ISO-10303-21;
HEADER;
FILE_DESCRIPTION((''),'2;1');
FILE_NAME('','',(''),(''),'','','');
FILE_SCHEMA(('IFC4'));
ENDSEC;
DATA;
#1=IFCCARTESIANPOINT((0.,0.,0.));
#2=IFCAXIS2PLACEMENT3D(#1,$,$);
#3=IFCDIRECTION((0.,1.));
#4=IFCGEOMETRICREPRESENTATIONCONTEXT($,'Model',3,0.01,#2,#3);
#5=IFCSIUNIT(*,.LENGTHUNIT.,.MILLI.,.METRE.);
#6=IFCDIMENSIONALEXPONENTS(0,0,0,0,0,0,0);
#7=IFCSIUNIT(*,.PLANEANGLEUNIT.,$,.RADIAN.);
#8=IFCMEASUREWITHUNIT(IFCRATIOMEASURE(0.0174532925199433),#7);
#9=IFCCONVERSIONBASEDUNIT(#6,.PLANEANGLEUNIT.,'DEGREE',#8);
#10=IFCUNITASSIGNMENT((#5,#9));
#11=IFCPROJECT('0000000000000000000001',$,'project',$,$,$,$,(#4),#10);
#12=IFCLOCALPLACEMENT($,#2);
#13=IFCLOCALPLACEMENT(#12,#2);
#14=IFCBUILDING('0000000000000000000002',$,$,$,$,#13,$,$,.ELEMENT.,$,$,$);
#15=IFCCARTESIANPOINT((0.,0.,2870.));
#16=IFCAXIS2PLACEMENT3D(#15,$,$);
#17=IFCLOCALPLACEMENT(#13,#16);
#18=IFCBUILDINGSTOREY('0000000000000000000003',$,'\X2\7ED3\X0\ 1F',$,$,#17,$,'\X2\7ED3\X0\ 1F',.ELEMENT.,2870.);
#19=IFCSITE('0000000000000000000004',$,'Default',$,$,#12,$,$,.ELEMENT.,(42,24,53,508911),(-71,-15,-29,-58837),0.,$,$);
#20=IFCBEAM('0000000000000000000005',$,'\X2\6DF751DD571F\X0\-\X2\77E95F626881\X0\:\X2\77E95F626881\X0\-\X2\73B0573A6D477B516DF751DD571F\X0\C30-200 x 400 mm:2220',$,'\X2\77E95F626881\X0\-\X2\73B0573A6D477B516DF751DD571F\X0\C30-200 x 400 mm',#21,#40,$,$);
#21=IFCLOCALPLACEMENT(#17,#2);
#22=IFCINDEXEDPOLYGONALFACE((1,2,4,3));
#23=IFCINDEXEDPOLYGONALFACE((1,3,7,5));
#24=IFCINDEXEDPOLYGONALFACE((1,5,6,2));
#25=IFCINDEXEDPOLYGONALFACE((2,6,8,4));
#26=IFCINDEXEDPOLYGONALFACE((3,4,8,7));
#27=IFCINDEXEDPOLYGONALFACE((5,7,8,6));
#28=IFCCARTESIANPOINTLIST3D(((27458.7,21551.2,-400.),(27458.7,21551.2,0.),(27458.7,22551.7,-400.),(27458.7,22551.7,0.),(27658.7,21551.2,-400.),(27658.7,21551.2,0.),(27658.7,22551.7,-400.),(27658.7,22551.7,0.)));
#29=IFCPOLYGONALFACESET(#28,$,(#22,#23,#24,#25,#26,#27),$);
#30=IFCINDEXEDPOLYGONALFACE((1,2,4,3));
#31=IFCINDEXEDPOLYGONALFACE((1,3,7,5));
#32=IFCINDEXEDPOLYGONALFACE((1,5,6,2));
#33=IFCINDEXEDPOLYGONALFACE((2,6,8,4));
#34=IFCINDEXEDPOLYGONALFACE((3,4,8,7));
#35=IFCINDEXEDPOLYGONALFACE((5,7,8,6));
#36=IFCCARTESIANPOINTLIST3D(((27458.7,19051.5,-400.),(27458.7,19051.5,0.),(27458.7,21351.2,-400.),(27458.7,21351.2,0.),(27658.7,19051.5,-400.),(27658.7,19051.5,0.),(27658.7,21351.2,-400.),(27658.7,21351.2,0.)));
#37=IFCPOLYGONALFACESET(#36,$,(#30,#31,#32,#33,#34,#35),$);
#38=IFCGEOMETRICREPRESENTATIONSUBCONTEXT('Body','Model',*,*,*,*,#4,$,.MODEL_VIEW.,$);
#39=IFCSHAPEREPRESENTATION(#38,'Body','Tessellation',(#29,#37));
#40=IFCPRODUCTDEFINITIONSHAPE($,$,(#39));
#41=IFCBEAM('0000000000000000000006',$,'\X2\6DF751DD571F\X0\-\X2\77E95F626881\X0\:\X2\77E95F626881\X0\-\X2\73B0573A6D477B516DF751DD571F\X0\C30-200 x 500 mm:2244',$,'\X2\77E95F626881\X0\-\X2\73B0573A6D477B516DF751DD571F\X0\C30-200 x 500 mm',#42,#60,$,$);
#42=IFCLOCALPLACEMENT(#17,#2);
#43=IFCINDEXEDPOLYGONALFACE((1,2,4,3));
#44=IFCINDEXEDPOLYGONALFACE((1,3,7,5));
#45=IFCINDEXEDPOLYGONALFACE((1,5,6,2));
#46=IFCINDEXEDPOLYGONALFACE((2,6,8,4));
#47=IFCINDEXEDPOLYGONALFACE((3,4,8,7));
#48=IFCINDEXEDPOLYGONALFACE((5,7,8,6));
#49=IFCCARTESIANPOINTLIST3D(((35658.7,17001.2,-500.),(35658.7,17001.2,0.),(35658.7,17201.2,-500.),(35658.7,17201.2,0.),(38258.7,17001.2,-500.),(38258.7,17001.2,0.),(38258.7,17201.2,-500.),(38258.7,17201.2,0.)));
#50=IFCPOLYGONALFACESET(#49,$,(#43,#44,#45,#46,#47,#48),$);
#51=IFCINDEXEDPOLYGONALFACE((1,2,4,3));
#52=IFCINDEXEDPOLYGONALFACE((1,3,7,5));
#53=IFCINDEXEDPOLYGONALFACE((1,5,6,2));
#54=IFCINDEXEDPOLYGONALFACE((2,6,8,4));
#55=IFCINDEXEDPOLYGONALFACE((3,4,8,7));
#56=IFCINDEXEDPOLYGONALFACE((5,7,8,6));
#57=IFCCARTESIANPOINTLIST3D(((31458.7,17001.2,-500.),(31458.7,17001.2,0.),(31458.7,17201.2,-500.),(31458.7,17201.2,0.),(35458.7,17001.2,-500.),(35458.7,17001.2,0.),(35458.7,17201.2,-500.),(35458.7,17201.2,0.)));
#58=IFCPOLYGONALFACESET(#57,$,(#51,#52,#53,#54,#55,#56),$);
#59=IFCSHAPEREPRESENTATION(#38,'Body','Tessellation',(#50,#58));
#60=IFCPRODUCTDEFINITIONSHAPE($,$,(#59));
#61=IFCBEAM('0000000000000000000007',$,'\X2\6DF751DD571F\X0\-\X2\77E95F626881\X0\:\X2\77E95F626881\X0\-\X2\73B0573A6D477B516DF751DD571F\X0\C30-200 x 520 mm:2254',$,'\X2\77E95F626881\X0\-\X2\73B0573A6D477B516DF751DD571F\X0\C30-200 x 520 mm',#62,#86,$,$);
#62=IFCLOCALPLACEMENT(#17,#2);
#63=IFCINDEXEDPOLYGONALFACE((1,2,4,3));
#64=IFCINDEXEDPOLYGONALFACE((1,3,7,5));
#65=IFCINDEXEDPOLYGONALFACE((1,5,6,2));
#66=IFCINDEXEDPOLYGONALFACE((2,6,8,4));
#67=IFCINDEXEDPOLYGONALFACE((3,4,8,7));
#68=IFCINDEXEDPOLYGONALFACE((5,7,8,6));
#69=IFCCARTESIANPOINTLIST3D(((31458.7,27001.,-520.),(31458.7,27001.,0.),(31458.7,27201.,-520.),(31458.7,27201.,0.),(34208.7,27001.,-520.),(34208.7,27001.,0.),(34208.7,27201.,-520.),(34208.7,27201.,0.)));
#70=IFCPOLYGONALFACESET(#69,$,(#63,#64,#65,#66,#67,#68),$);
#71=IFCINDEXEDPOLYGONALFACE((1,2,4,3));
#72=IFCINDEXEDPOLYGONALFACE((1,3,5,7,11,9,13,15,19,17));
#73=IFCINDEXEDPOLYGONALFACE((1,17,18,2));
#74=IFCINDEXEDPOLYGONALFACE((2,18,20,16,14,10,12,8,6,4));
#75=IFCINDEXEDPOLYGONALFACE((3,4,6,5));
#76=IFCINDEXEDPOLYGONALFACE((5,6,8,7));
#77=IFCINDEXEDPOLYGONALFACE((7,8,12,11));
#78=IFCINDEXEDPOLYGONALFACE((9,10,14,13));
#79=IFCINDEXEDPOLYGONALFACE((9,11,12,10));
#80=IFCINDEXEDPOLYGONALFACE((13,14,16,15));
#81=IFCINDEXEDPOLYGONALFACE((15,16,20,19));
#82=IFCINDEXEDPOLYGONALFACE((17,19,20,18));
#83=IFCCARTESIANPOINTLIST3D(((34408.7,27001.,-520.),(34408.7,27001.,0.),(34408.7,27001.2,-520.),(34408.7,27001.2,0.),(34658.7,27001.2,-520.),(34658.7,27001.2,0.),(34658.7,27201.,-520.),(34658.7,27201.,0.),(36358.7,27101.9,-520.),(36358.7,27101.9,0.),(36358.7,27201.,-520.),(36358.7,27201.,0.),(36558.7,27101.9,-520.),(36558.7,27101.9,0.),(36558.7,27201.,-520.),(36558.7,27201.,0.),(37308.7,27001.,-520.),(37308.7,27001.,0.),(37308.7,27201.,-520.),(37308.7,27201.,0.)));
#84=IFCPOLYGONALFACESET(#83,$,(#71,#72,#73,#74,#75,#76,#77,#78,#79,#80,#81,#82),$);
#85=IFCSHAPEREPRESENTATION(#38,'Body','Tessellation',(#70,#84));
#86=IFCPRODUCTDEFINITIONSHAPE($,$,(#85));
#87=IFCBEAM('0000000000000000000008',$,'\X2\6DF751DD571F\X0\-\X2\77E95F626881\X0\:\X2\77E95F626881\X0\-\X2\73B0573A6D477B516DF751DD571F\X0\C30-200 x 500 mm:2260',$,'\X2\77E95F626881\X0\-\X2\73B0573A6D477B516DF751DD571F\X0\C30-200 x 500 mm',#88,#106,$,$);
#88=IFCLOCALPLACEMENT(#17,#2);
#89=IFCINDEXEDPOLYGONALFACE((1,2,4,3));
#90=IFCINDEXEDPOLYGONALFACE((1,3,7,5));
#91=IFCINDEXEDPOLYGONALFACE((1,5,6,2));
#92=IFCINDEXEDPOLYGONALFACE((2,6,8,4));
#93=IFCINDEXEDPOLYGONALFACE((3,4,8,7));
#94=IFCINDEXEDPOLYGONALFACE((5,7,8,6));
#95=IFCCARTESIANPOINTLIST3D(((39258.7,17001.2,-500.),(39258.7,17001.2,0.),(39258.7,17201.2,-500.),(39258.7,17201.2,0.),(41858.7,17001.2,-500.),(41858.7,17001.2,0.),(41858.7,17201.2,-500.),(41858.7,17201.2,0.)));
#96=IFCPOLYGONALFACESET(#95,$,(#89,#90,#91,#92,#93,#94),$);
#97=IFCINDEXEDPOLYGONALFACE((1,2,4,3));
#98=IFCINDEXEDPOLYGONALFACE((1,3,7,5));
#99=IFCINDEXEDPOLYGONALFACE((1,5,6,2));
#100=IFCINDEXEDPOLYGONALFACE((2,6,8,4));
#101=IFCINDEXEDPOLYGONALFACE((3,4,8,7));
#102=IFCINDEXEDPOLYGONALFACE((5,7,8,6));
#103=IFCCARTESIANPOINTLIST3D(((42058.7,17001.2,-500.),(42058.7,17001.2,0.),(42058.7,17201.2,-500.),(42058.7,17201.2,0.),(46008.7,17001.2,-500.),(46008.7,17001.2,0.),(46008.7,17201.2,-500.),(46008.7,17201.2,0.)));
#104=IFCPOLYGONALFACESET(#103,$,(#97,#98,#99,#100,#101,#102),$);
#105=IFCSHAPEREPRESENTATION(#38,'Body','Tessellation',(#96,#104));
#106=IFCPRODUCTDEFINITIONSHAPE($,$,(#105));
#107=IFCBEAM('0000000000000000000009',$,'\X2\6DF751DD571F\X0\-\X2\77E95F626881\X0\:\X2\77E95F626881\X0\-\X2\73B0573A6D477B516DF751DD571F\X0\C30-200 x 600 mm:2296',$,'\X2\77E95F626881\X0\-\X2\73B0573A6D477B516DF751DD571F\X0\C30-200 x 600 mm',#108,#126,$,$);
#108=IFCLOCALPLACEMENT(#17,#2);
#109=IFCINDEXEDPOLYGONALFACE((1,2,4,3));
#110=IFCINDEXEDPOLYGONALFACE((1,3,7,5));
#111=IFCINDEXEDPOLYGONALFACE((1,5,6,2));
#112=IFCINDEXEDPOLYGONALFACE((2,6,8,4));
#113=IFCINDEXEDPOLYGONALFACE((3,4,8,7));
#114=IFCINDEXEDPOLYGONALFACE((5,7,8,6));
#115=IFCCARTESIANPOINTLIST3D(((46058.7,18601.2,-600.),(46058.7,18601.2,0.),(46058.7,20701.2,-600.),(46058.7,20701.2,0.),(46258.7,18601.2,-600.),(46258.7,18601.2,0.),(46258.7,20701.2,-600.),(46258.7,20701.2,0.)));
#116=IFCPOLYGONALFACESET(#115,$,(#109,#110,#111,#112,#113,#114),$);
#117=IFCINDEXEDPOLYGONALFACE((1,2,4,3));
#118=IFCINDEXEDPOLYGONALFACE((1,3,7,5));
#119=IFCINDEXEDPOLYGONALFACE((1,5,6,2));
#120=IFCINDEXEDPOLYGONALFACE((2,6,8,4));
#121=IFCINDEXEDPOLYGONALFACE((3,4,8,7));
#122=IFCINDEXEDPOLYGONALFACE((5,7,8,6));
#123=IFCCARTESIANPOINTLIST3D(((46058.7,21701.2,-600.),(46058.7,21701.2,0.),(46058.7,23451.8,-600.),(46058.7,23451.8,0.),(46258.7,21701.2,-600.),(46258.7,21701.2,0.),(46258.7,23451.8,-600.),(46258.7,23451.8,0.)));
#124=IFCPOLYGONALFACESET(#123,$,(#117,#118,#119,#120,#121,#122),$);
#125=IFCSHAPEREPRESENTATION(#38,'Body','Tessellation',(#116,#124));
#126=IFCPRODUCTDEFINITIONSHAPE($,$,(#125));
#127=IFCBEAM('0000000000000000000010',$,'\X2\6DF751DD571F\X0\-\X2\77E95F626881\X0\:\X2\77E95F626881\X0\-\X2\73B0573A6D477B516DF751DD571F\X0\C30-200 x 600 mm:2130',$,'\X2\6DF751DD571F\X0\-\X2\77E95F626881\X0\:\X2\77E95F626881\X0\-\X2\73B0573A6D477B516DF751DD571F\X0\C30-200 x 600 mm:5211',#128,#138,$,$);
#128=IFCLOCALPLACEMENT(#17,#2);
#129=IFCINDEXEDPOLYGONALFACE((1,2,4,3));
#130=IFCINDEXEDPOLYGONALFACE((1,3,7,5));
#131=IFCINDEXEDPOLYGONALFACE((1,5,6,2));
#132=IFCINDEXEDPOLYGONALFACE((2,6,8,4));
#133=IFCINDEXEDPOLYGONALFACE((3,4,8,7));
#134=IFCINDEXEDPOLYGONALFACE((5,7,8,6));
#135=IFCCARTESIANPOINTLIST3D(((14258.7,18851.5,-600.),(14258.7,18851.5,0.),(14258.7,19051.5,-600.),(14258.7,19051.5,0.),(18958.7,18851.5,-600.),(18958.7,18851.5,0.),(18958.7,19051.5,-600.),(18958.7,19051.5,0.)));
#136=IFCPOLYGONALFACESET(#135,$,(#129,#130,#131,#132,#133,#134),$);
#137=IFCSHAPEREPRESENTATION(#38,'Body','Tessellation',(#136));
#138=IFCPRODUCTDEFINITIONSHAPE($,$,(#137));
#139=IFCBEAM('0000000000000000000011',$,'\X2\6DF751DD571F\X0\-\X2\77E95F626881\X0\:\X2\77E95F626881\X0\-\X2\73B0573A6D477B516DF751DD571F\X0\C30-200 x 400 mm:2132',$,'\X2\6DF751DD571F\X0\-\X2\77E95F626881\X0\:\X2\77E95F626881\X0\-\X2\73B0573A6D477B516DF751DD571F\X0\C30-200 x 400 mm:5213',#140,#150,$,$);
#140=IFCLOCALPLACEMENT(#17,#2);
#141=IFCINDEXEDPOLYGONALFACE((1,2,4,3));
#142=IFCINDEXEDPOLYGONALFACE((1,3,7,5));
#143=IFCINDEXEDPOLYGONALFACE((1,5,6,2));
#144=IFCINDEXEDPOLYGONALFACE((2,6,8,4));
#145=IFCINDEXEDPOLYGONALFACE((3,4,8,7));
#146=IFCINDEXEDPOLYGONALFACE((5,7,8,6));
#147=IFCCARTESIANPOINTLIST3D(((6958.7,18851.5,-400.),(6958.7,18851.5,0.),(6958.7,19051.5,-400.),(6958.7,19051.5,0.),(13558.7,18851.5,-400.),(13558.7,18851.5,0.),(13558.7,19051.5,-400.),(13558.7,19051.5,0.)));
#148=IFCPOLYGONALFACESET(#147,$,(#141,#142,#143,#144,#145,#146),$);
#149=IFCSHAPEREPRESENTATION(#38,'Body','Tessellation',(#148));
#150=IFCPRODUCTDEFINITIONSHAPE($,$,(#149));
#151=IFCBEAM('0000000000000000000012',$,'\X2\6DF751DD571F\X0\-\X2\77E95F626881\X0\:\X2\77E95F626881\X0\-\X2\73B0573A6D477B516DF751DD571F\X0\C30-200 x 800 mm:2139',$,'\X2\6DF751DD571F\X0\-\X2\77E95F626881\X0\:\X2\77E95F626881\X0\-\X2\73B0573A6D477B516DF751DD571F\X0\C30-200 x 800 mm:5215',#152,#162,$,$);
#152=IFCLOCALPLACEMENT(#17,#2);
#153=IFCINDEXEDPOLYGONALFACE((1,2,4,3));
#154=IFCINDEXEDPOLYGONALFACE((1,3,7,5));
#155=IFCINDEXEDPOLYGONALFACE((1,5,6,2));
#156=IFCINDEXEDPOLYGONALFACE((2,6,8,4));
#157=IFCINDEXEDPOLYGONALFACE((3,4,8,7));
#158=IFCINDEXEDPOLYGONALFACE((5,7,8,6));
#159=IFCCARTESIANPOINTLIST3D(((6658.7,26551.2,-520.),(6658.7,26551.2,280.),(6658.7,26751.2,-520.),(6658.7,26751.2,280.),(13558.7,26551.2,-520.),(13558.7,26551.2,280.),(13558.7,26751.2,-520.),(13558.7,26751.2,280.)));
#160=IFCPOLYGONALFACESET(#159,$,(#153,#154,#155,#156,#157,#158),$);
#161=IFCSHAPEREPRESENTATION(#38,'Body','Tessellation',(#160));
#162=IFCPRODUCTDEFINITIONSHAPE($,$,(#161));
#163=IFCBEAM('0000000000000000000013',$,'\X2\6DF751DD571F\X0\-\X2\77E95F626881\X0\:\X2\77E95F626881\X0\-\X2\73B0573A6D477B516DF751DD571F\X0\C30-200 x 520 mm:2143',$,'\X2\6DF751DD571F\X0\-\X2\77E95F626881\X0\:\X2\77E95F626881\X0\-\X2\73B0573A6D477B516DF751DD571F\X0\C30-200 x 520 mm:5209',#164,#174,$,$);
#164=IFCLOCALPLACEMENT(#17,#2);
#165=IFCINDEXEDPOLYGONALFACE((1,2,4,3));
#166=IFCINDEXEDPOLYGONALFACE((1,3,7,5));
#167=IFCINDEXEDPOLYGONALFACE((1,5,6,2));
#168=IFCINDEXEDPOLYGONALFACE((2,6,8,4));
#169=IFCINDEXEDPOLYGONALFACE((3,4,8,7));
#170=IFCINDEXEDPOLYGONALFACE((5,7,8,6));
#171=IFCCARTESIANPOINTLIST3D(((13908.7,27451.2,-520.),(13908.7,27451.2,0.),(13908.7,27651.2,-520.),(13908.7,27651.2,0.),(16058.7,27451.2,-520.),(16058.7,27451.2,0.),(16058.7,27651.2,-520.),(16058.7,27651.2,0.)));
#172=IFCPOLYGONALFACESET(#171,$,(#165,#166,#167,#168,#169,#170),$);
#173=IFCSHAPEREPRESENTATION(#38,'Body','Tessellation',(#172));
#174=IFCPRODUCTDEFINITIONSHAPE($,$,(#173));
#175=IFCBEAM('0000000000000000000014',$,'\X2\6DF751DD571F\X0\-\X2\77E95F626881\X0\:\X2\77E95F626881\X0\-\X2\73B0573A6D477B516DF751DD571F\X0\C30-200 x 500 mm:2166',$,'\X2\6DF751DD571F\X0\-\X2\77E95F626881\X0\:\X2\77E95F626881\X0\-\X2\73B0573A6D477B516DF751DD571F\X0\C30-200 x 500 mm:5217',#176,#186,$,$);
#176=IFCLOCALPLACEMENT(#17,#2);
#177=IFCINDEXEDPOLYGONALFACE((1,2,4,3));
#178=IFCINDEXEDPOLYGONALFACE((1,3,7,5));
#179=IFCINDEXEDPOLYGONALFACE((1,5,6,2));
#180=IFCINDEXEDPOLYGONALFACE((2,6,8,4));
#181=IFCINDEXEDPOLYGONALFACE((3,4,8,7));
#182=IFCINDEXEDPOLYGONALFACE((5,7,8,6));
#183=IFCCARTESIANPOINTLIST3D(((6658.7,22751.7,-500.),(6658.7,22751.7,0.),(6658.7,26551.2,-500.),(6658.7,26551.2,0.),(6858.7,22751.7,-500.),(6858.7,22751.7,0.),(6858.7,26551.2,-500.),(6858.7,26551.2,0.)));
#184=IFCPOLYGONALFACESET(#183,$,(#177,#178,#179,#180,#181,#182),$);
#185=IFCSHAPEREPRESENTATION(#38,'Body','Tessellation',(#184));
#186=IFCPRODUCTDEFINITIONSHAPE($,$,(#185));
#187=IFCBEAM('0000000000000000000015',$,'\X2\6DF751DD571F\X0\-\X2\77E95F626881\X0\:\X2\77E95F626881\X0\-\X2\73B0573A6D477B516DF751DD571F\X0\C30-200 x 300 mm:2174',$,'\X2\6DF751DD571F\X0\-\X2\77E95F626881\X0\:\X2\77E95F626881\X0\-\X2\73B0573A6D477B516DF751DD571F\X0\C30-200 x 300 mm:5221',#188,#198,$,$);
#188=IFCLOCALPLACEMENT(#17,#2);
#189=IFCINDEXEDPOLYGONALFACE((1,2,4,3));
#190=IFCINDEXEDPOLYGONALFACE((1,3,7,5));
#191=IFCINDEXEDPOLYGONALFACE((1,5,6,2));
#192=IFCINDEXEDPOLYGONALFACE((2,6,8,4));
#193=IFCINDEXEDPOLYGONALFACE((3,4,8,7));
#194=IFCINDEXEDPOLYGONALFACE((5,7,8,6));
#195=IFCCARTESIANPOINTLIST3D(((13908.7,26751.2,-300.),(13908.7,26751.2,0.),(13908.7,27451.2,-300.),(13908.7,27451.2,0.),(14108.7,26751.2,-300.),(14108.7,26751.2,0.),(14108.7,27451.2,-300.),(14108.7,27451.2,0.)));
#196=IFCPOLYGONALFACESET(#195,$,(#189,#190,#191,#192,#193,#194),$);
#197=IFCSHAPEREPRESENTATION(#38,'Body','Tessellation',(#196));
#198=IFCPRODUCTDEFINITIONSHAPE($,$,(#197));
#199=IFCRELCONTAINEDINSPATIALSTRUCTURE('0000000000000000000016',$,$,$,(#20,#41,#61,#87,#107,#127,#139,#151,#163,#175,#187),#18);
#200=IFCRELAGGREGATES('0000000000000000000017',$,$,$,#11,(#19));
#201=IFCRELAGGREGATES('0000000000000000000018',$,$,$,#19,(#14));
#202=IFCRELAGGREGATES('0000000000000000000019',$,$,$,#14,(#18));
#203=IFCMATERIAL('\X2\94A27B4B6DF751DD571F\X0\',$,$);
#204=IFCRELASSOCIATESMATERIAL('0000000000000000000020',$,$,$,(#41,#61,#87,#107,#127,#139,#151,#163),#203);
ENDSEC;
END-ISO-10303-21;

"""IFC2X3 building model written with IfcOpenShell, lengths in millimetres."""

from ifc_helpers import new_model, entity, si_unit, converted_unit, direction, frame, frame_2d, origin, place, context, subcontext, project, spatial, polyline, rectangle, outline, extrude, source, transform, mapped, material, element, save


model = new_model("IFC2X3")

# Units and contexts
model_context = context("Model", 3, precision=0.01, world=origin(), true_north=direction((0.0, 1.0)))
body_context = subcontext(model_context, "Body", "Model", "MODEL_VIEW")
ifc_project = project(units=[si_unit("LENGTHUNIT", "METRE", prefix="MILLI"), converted_unit("PLANEANGLEUNIT", "DEGREE", entity("IfcRatioMeasure", 0.0174532925199433), si_unit("PLANEANGLEUNIT", "RADIAN"), dimensions=[0, 0, 0, 0, 0, 0, 0])], contexts=[model_context])

# Site, building, storey
site_placement = place(None, origin())
site = spatial("IfcSite", under=ifc_project, at=site_placement, Name="Default", CompositionType="ELEMENT", RefLatitude=(42, 24, 53, 508911), RefLongitude=(-71, -15, -29, -58837), RefElevation=0.0)
building_placement = place(site_placement, origin())
building = spatial("IfcBuilding", under=site, at=building_placement, CompositionType="ELEMENT")
storey_placement = place(building_placement, frame((0.0, 0.0, 2870.0)))
storey = spatial("IfcBuildingStorey", under=building, at=storey_placement, Name="结 1F", LongName="结 1F", CompositionType="ELEMENT", Elevation=2870.0)

# Beams
ifc_material = material(Name="钢筋混凝土")
shared_shape_1 = source(origin(), body_context, "Body", "SweptSolid", [
    extrude(rectangle(XDim=1000.5, YDim=200.0, at=frame_2d((0.0, 0.0), x_axis=(1.0, 0.0))), frame((27558.7, 22051.5, 2470.0), z_axis=(0.0, 0.0, 1.0), x_axis=(0.0, -1.0, 0.0)), (0.0, 0.0, 1.0), 400.0),
    extrude(rectangle(XDim=2299.8, YDim=200.0, at=frame_2d((0.0, 0.0), x_axis=(1.0, 0.0))), frame((27558.7, 20201.3, 2470.0), z_axis=(0.0, 0.0, 1.0), x_axis=(0.0, 1.0, 0.0)), (0.0, 0.0, 1.0), 400.0),
])
beam_1_placement = place(storey_placement, frame((0.0, 0.0, -2870.0)))
element("IfcBeam", 1, at=beam_1_placement, inside=storey, Name="混凝土-矩形梁:矩形梁-现场浇筑混凝土C30-200 x 400 mm:2220", ObjectType="矩形梁-现场浇筑混凝土C30-200 x 400 mm", context=body_context, shape_type="MappedRepresentation", body=[
    mapped(shared_shape_1, transform((0.0, 0.0, 0.0), scale=1.0)),
])
shared_shape_2 = source(origin(), body_context, "Body", "SweptSolid", [
    extrude(rectangle(XDim=2600.0, YDim=200.0, at=frame_2d((0.0, 0.0), x_axis=(1.0, 0.0))), frame((36958.7, 17101.2, 2370.0), z_axis=(0.0, 0.0, 1.0), x_axis=(-1.0, 0.0, 0.0)), (0.0, 0.0, 1.0), 500.0),
    extrude(rectangle(XDim=4000.0, YDim=200.0, at=frame_2d((0.0, 0.0), x_axis=(1.0, 0.0))), frame((33458.7, 17101.2, 2370.0)), (0.0, 0.0, 1.0), 500.0),
])
beam_2_placement = place(storey_placement, frame((0.0, 0.0, -2870.0)))
element("IfcBeam", 2, at=beam_2_placement, inside=storey, material=ifc_material, Name="混凝土-矩形梁:矩形梁-现场浇筑混凝土C30-200 x 500 mm:2244", ObjectType="矩形梁-现场浇筑混凝土C30-200 x 500 mm", context=body_context, shape_type="MappedRepresentation", body=[
    mapped(shared_shape_2, transform((0.0, 0.0, 0.0), scale=1.0)),
])
shared_shape_3 = source(origin(), body_context, "Body", "SweptSolid", [
    extrude(rectangle(XDim=2750.0, YDim=200.0, at=frame_2d((0.0, 0.0), x_axis=(1.0, 0.0))), frame((32833.7, 27101.0, 2350.0), z_axis=(0.0, 0.0, 1.0), x_axis=(-1.0, 0.0, 0.0)), (0.0, 0.0, 1.0), 520.0),
    extrude(outline(polyline([(-1450.0, -99.8), (-700.0, -99.8), (-700.0, -0.7), (-500.0, -0.7), (-500.0, -99.8), (1200.0, -99.8), (1200.0, 100.0), (1450.0, 100.0), (1450.0, 100.2), (-1450.0, 100.2), (-1450.0, -99.8)])), frame((35858.7, 27101.2, 2350.0), z_axis=(0.0, 0.0, 1.0), x_axis=(-1.0, 0.0, 0.0)), (0.0, 0.0, 1.0), 520.0),
])
beam_3_placement = place(storey_placement, frame((0.0, 0.0, -2870.0)))
element("IfcBeam", 3, at=beam_3_placement, inside=storey, material=ifc_material, Name="混凝土-矩形梁:矩形梁-现场浇筑混凝土C30-200 x 520 mm:2254", ObjectType="矩形梁-现场浇筑混凝土C30-200 x 520 mm", context=body_context, shape_type="MappedRepresentation", body=[
    mapped(shared_shape_3, transform((0.0, 0.0, 0.0), scale=1.0)),
])
shared_shape_4 = source(origin(), body_context, "Body", "SweptSolid", [
    extrude(rectangle(XDim=2600.0, YDim=200.0, at=frame_2d((0.0, 0.0), x_axis=(1.0, 0.0))), frame((40558.7, 17101.2, 2370.0)), (0.0, 0.0, 1.0), 500.0),
    extrude(rectangle(XDim=3950.0, YDim=200.0, at=frame_2d((0.0, 0.0), x_axis=(1.0, 0.0))), frame((44033.7, 17101.2, 2370.0), z_axis=(0.0, 0.0, 1.0), x_axis=(-1.0, 0.0, 0.0)), (0.0, 0.0, 1.0), 500.0),
])
beam_4_placement = place(storey_placement, frame((0.0, 0.0, -2870.0)))
element("IfcBeam", 4, at=beam_4_placement, inside=storey, material=ifc_material, Name="混凝土-矩形梁:矩形梁-现场浇筑混凝土C30-200 x 500 mm:2260", ObjectType="矩形梁-现场浇筑混凝土C30-200 x 500 mm", context=body_context, shape_type="MappedRepresentation", body=[
    mapped(shared_shape_4, transform((0.0, 0.0, 0.0), scale=1.0)),
])
shared_shape_5 = source(origin(), body_context, "Body", "SweptSolid", [
    extrude(rectangle(XDim=2100.0, YDim=200.0, at=frame_2d((0.0, 0.0), x_axis=(1.0, 0.0))), frame((46158.7, 19651.2, 2270.0), z_axis=(0.0, 0.0, 1.0), x_axis=(0.0, 1.0, 0.0)), (0.0, 0.0, 1.0), 600.0),
    extrude(rectangle(XDim=1750.6, YDim=200.0, at=frame_2d((0.0, 0.0), x_axis=(1.0, 0.0))), frame((46158.7, 22576.5, 2270.0), z_axis=(0.0, 0.0, 1.0), x_axis=(0.0, -1.0, 0.0)), (0.0, 0.0, 1.0), 600.0),
])
beam_5_placement = place(storey_placement, frame((0.0, 0.0, -2870.0)))
element("IfcBeam", 5, at=beam_5_placement, inside=storey, material=ifc_material, Name="混凝土-矩形梁:矩形梁-现场浇筑混凝土C30-200 x 600 mm:2296", ObjectType="矩形梁-现场浇筑混凝土C30-200 x 600 mm", context=body_context, shape_type="MappedRepresentation", body=[
    mapped(shared_shape_5, transform((0.0, 0.0, 0.0), scale=1.0)),
])
beam_6_placement = place(storey_placement, frame((13658.7, 18951.5, 0.0)))
element("IfcBeam", 6, at=beam_6_placement, inside=storey, material=ifc_material, Name="混凝土-矩形梁:矩形梁-现场浇筑混凝土C30-200 x 600 mm:2130", ObjectType="混凝土-矩形梁:矩形梁-现场浇筑混凝土C30-200 x 600 mm:5211", context=body_context, shape_type="SweptSolid", body=[
    extrude(rectangle(XDim=600.0, YDim=200.0, at=frame_2d((0.0, 0.0), x_axis=(1.0, 0.0))), frame((600.0, 0.0, -300.0), z_axis=(1.0, 0.0, 0.0), x_axis=(0.0, 0.0, -1.0)), (0.0, 0.0, 1.0), 4700.0),
])
beam_7_placement = place(storey_placement, frame((13658.7, 18951.5, 0.0), z_axis=(0.0, 0.0, 1.0), x_axis=(-1.0, 0.0, 0.0)))
element("IfcBeam", 7, at=beam_7_placement, inside=storey, material=ifc_material, Name="混凝土-矩形梁:矩形梁-现场浇筑混凝土C30-200 x 400 mm:2132", ObjectType="混凝土-矩形梁:矩形梁-现场浇筑混凝土C30-200 x 400 mm:5213", context=body_context, shape_type="SweptSolid", body=[
    extrude(rectangle(XDim=400.0, YDim=200.0, at=frame_2d((0.0, 0.0), x_axis=(1.0, 0.0))), frame((100.0, 0.0, -200.0), z_axis=(1.0, 0.0, 0.0), x_axis=(0.0, 0.0, -1.0)), (0.0, 0.0, 1.0), 6600.0),
])
beam_8_placement = place(storey_placement, frame((6658.7, 26651.2, 280.0)))
element("IfcBeam", 8, at=beam_8_placement, inside=storey, material=ifc_material, Name="混凝土-矩形梁:矩形梁-现场浇筑混凝土C30-200 x 800 mm:2139", ObjectType="混凝土-矩形梁:矩形梁-现场浇筑混凝土C30-200 x 800 mm:5215", context=body_context, shape_type="SweptSolid", body=[
    extrude(rectangle(XDim=800.0, YDim=200.0, at=frame_2d((0.0, 0.0), x_axis=(1.0, 0.0))), frame((0.0, 0.0, -400.0), z_axis=(1.0, 0.0, 0.0), x_axis=(0.0, 0.0, -1.0)), (0.0, 0.0, 1.0), 6900.0),
])
beam_9_placement = place(storey_placement, frame((14008.7, 27551.2, 0.0)))
element("IfcBeam", 9, at=beam_9_placement, inside=storey, material=ifc_material, Name="混凝土-矩形梁:矩形梁-现场浇筑混凝土C30-200 x 520 mm:2143", ObjectType="混凝土-矩形梁:矩形梁-现场浇筑混凝土C30-200 x 520 mm:5209", context=body_context, shape_type="SweptSolid", body=[
    extrude(rectangle(XDim=520.0, YDim=200.0, at=frame_2d((0.0, 0.0), x_axis=(1.0, 0.0))), frame((-100.0, 0.0, -260.0), z_axis=(1.0, 0.0, 0.0), x_axis=(0.0, 0.0, -1.0)), (0.0, 0.0, 1.0), 2150.0),
])
beam_10_placement = place(storey_placement, frame((6758.7, 22651.7, 0.0), z_axis=(0.0, 0.0, 1.0), x_axis=(0.0, 1.0, 0.0)))
element("IfcBeam", 10, at=beam_10_placement, inside=storey, Name="混凝土-矩形梁:矩形梁-现场浇筑混凝土C30-200 x 500 mm:2166", ObjectType="混凝土-矩形梁:矩形梁-现场浇筑混凝土C30-200 x 500 mm:5217", context=body_context, shape_type="SweptSolid", body=[
    extrude(rectangle(XDim=500.0, YDim=200.0, at=frame_2d((0.0, 0.0), x_axis=(1.0, 0.0))), frame((100.0, 0.0, -250.0), z_axis=(1.0, 0.0, 0.0), x_axis=(0.0, 0.0, -1.0)), (0.0, 0.0, 1.0), 3799.5),
])
beam_11_placement = place(storey_placement, frame((14008.7, 26651.2, 0.0), z_axis=(0.0, 0.0, 1.0), x_axis=(0.0, 1.0, 0.0)))
element("IfcBeam", 11, at=beam_11_placement, inside=storey, Name="混凝土-矩形梁:矩形梁-现场浇筑混凝土C30-200 x 300 mm:2174", ObjectType="混凝土-矩形梁:矩形梁-现场浇筑混凝土C30-200 x 300 mm:5221", context=body_context, shape_type="SweptSolid", body=[
    extrude(rectangle(XDim=300.0, YDim=200.0, at=frame_2d((0.0, 0.0), x_axis=(1.0, 0.0))), frame((100.0, 0.0, -150.0), z_axis=(1.0, 0.0, 0.0), x_axis=(0.0, 0.0, -1.0)), (0.0, 0.0, 1.0), 700.0),
])

save(model, "model.ifc")
